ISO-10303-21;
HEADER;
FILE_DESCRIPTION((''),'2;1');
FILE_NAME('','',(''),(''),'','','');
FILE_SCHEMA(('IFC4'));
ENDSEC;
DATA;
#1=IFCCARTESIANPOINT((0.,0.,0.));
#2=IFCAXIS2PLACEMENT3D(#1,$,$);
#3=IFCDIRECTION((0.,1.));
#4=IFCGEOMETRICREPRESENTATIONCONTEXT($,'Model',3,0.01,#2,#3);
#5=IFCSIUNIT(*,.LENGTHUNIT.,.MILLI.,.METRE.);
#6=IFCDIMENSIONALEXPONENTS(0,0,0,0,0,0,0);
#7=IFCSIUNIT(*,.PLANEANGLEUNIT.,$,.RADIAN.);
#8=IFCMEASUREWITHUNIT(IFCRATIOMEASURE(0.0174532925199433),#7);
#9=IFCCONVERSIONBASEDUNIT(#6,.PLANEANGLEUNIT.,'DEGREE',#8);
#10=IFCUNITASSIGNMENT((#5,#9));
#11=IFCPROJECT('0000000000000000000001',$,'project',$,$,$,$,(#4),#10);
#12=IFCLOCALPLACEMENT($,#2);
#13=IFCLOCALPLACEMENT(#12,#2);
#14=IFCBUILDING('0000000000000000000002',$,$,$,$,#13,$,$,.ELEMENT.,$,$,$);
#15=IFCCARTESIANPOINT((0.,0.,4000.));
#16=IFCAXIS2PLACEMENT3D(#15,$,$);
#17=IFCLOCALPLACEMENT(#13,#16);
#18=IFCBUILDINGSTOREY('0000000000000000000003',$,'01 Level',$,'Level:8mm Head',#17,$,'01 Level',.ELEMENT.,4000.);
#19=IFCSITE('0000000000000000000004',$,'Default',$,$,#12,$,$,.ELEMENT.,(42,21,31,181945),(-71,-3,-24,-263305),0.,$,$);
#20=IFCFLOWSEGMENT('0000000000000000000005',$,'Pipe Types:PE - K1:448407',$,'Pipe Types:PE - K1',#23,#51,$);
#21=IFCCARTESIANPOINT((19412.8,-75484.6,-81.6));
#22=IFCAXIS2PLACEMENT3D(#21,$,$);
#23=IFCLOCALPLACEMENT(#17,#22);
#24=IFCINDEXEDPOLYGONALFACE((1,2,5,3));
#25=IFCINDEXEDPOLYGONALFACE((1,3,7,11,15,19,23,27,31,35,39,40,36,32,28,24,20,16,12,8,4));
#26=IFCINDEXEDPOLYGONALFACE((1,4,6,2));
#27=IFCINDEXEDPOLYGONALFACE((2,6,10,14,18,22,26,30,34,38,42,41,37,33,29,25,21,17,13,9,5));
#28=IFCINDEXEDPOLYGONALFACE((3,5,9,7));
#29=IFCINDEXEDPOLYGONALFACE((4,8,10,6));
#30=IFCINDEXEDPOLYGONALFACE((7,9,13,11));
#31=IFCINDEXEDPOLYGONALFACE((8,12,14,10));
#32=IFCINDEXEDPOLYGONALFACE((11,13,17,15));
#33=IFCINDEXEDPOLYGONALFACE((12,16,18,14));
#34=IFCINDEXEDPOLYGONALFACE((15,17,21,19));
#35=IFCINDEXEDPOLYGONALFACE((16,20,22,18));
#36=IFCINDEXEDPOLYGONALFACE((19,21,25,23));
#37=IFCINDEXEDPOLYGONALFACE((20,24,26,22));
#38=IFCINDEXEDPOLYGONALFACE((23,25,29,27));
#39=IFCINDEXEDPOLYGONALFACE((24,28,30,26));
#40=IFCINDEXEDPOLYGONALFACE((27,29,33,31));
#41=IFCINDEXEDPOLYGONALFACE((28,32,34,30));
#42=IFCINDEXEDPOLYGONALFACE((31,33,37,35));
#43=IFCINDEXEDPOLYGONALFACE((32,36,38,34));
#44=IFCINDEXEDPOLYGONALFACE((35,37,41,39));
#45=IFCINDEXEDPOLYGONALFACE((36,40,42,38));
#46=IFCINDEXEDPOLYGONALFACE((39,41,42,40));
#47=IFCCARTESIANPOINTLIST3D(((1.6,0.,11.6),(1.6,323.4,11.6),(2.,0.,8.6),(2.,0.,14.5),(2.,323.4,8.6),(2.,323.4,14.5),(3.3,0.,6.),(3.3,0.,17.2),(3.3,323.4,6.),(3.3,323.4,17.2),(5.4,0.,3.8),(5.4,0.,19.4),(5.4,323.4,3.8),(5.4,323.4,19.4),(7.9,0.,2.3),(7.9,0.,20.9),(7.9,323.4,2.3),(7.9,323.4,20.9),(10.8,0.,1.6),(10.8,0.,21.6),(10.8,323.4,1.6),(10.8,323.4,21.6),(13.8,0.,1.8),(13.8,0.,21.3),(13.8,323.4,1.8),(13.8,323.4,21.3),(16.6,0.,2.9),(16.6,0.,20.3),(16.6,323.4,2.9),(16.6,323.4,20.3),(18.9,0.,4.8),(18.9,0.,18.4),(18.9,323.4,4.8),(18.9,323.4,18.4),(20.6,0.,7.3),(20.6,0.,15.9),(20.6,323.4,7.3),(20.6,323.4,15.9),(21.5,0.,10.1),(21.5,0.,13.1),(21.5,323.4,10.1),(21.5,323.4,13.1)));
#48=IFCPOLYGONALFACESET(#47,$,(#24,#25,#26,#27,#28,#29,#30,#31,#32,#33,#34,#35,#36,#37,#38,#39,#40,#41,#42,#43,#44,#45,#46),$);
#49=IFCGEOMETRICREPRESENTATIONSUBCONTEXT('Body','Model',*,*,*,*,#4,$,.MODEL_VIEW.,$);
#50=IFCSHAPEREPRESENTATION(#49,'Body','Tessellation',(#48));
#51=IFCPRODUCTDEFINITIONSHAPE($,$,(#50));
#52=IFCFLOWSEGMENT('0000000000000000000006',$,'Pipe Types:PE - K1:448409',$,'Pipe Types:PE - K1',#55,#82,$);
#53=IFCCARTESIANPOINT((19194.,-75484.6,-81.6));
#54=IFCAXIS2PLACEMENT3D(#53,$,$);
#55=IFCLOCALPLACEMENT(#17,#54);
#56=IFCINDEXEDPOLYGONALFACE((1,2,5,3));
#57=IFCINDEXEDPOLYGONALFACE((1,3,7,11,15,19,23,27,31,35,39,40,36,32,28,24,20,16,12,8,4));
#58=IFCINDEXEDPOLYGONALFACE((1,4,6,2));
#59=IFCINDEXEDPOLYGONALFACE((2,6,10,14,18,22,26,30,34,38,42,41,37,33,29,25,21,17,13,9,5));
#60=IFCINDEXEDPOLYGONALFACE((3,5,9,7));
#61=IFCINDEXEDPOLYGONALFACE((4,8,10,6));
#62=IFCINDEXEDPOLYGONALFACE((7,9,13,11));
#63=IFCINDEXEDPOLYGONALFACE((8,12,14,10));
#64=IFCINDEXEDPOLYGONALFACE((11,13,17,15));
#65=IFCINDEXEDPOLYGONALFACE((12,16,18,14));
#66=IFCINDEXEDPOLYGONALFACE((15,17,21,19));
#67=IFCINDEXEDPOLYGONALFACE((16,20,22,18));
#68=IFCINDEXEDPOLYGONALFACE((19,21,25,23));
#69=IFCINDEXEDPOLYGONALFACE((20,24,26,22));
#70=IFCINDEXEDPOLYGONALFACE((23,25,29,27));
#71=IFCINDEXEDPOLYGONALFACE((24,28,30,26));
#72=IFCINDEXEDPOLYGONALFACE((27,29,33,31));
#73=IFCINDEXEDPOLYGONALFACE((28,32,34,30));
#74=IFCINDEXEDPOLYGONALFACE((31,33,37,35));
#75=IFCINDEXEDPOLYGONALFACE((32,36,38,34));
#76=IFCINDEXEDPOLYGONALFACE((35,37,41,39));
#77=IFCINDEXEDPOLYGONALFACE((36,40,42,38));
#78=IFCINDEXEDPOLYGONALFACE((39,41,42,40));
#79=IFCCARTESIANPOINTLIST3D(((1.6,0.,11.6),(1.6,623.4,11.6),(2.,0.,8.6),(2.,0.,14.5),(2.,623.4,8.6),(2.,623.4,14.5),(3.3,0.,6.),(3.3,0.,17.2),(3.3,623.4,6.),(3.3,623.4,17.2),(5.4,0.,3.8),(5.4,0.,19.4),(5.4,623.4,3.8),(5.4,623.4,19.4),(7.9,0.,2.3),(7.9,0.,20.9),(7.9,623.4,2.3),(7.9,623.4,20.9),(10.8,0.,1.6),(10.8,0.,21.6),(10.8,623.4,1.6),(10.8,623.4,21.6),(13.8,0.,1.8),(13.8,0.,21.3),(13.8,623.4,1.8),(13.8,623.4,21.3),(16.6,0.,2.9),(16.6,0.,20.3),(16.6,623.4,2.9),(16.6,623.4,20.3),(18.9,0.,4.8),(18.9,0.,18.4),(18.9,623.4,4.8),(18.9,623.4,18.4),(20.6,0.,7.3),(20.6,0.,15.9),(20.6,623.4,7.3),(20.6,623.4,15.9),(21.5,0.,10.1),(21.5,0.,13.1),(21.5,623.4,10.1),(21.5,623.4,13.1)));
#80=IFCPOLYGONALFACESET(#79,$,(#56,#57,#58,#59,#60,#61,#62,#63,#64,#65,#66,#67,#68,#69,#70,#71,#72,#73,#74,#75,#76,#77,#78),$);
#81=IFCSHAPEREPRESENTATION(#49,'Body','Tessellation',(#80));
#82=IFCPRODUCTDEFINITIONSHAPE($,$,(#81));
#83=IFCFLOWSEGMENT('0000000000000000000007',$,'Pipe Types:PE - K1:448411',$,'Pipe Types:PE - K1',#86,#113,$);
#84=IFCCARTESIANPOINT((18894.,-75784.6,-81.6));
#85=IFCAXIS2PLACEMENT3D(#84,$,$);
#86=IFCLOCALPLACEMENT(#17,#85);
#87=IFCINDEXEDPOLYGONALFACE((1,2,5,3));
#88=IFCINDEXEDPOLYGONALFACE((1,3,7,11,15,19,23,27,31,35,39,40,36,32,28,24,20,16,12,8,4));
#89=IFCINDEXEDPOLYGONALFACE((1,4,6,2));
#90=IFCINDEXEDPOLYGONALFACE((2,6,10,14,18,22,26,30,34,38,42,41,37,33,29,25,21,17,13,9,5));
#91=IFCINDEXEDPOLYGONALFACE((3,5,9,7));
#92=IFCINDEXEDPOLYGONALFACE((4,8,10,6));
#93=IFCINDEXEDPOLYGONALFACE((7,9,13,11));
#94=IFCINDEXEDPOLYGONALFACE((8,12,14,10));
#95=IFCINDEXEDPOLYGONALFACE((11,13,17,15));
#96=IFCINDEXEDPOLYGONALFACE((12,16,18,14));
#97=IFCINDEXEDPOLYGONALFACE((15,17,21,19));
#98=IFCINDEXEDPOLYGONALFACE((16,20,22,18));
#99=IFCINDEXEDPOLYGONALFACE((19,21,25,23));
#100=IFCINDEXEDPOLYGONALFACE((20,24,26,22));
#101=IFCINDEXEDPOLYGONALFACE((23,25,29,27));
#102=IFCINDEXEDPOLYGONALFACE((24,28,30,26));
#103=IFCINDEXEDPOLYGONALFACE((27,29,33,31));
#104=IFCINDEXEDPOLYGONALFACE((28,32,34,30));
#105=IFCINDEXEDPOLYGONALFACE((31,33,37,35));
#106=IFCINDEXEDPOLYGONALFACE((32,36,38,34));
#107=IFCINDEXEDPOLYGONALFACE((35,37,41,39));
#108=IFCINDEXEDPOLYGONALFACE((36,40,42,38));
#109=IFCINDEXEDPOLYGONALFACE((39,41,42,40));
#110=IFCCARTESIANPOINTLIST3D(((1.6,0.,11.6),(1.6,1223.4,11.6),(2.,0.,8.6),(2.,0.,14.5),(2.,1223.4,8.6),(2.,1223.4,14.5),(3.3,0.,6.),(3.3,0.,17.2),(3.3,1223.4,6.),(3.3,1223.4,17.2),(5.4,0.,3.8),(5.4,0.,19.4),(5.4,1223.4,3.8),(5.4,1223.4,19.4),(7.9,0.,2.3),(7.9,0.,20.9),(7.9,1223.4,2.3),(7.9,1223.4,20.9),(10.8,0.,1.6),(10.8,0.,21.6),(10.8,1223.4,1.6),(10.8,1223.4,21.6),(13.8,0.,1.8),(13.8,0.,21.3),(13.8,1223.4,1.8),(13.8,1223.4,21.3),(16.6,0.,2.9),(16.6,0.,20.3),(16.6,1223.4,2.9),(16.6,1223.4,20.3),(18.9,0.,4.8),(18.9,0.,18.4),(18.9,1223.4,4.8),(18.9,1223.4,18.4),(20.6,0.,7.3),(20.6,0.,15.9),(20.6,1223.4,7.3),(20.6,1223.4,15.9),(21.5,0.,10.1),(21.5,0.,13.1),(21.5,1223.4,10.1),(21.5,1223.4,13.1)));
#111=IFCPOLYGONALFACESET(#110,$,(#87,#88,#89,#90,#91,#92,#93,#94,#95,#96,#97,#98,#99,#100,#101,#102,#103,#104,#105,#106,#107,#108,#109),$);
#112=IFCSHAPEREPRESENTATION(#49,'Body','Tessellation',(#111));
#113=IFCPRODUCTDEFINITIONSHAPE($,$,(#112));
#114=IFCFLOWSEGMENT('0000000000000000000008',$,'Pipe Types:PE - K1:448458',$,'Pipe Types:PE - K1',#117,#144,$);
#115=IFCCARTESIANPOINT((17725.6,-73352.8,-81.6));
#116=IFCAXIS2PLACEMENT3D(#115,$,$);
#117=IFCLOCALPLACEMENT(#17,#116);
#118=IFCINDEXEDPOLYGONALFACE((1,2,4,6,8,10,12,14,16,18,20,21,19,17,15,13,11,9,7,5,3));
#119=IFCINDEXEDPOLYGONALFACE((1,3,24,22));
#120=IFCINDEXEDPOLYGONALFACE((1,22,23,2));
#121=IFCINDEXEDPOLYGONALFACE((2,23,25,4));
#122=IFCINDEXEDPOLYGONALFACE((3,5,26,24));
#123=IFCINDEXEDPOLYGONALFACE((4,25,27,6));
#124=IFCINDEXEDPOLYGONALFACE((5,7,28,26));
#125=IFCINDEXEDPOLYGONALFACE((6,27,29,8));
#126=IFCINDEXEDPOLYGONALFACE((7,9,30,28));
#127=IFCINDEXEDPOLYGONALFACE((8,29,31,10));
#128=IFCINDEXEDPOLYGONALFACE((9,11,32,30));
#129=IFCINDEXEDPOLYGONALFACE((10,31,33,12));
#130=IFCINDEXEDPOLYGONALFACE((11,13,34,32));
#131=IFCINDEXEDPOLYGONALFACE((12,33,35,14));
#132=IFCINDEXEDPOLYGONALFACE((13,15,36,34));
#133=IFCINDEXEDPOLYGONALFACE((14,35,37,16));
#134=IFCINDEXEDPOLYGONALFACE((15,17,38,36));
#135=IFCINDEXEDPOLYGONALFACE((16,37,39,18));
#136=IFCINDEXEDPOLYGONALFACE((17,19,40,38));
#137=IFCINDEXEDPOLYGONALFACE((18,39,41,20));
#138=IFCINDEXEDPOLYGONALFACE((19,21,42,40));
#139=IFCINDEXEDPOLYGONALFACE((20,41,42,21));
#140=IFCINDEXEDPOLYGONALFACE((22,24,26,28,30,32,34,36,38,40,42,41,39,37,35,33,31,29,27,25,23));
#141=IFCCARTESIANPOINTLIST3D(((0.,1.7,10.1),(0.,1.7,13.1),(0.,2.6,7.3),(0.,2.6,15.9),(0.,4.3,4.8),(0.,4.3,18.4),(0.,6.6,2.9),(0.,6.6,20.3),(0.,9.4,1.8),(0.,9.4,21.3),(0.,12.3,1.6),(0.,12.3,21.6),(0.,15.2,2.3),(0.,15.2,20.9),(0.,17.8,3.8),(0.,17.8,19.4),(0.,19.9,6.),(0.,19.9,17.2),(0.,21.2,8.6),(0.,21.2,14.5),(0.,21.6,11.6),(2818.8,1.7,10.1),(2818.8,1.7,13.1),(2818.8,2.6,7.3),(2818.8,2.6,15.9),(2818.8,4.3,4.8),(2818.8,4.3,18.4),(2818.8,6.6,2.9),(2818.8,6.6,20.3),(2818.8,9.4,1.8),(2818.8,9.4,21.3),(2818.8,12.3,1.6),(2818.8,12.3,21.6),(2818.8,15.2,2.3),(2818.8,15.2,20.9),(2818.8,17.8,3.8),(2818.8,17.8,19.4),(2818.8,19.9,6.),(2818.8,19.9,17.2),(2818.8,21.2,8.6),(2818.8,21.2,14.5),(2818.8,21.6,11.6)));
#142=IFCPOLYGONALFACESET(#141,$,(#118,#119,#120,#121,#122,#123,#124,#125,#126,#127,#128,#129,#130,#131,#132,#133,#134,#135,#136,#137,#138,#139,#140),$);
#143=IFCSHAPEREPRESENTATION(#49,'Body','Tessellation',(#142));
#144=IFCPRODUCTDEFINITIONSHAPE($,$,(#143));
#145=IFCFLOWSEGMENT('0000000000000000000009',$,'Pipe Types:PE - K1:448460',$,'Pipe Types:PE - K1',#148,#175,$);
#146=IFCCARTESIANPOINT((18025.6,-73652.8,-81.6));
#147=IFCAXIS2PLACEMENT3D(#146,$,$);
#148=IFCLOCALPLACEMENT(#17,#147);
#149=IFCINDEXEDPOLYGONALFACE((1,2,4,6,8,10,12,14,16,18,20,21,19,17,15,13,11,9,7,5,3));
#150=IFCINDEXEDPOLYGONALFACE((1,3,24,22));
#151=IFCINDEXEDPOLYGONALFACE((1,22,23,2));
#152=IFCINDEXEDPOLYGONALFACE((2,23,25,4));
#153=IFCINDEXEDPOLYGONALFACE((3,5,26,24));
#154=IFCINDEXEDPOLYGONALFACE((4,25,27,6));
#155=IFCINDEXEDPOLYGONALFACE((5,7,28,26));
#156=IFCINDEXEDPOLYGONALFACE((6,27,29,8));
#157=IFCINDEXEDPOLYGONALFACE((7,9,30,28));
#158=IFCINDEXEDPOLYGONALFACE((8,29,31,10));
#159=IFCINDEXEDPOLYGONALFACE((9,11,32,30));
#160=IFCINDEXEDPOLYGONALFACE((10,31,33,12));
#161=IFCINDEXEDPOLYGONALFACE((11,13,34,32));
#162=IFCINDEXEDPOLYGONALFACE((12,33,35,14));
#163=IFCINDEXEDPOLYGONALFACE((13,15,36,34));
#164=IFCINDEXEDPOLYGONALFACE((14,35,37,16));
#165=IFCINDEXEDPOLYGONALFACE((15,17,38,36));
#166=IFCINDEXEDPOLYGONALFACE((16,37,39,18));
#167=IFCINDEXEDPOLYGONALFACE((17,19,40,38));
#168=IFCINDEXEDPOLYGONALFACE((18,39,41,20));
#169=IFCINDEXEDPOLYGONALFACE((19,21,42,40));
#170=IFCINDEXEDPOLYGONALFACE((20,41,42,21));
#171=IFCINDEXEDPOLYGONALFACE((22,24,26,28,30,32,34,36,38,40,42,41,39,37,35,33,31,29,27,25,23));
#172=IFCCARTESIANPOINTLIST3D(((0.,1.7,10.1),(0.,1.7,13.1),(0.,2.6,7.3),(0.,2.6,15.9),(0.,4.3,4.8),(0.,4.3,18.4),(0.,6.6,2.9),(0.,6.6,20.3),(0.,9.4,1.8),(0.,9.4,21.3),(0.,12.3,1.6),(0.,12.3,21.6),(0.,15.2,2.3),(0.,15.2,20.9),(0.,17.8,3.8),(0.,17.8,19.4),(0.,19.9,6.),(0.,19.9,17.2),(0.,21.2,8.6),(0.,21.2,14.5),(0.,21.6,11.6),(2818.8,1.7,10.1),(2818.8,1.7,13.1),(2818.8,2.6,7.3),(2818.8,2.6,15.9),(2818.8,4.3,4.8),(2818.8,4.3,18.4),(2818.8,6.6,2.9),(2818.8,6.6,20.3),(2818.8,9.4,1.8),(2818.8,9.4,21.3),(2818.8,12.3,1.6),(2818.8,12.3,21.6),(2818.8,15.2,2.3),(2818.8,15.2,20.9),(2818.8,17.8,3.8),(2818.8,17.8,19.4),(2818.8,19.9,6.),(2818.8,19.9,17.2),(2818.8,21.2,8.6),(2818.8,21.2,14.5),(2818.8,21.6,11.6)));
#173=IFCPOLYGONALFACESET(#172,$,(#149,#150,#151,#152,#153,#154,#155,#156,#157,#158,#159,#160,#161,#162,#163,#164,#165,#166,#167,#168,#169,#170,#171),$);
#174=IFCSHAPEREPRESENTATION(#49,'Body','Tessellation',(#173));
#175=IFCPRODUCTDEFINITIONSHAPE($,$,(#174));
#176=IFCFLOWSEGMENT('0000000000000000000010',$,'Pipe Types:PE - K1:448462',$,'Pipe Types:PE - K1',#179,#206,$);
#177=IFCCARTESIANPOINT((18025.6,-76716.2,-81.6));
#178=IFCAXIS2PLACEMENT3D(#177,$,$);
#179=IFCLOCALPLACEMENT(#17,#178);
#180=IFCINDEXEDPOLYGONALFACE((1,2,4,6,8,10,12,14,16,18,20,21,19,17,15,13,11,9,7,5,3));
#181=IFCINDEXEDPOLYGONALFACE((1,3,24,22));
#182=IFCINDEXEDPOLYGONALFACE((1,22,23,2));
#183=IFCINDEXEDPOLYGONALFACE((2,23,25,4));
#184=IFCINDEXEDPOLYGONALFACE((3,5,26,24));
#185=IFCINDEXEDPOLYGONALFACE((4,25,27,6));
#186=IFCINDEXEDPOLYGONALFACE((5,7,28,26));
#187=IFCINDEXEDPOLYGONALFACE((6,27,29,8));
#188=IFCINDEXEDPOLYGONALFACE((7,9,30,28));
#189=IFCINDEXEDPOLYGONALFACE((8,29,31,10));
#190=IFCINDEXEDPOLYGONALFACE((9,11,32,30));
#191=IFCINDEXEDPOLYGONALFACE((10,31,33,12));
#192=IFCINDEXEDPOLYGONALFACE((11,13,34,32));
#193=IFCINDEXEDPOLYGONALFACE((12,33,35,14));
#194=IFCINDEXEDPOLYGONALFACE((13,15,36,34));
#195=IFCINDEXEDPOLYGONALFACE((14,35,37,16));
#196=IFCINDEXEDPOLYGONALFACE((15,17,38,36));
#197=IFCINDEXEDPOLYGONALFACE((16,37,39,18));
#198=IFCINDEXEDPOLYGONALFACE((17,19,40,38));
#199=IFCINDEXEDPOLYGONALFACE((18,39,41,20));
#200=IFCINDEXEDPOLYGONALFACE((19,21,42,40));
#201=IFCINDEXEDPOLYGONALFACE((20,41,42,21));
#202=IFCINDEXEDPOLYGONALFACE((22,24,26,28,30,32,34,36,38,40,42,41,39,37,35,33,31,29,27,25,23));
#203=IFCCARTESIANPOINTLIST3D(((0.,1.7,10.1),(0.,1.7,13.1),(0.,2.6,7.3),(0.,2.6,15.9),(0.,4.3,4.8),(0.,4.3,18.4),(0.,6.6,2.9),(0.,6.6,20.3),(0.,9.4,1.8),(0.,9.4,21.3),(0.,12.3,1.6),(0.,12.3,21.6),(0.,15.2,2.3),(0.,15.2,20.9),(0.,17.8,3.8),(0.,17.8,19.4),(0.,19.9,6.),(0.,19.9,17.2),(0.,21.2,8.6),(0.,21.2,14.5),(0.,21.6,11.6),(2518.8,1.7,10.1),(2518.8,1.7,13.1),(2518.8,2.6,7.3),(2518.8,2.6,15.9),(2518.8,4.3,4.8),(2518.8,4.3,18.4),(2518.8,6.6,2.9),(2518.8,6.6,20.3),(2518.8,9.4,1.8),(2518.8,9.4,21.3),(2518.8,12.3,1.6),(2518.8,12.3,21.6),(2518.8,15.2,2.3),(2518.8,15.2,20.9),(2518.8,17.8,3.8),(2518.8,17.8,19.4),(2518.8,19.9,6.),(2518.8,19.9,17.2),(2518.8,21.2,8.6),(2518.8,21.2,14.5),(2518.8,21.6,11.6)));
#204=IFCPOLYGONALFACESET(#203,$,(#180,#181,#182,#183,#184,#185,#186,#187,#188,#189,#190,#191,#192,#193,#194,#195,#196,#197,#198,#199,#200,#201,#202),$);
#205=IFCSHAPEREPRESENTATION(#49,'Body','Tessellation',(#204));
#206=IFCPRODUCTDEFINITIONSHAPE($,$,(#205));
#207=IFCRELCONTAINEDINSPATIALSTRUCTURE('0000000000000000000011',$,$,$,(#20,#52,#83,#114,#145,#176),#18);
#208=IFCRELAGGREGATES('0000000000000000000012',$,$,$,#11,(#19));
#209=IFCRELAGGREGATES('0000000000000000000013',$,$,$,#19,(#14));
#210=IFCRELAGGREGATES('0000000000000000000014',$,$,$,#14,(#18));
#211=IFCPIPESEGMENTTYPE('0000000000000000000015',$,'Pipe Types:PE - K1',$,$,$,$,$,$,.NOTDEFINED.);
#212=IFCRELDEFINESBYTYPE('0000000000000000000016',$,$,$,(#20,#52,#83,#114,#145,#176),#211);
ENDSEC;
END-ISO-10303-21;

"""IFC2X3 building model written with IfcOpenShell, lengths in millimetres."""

from ifc_helpers import new_model, entity, si_unit, converted_unit, direction, frame, frame_2d, origin, place, context, subcontext, project, spatial, circle, extrude, type_object, element, save


model = new_model("IFC2X3")

# Units and contexts
model_context = context("Model", 3, precision=0.01, world=origin(), true_north=direction((0.0, 1.0)))
body_context = subcontext(model_context, "Body", "Model", "MODEL_VIEW")
ifc_project = project(units=[si_unit("LENGTHUNIT", "METRE", prefix="MILLI"), converted_unit("PLANEANGLEUNIT", "DEGREE", entity("IfcRatioMeasure", 0.0174532925199433), si_unit("PLANEANGLEUNIT", "RADIAN"), dimensions=[0, 0, 0, 0, 0, 0, 0])], contexts=[model_context])

# Site, building, storey
site_placement = place(None, origin())
site = spatial("IfcSite", under=ifc_project, at=site_placement, Name="Default", CompositionType="ELEMENT", RefLatitude=(42, 21, 31, 181945), RefLongitude=(-71, -3, -24, -263305), RefElevation=0.0)
building_placement = place(site_placement, origin())
building = spatial("IfcBuilding", under=site, at=building_placement, CompositionType="ELEMENT")
storey_placement = place(building_placement, frame((0.0, 0.0, 4000.0)))
storey = spatial("IfcBuildingStorey", under=building, at=storey_placement, Name="01 Level", ObjectType="Level:8mm Head", LongName="01 Level", CompositionType="ELEMENT", Elevation=4000.0)

# Flow segments
pipe_segment_type = type_object("IfcPipeSegmentType", Name="Pipe Types:PE - K1", PredefinedType="NOTDEFINED")
flow_segment_1_placement = place(storey_placement, frame((19412.8, -75484.6, -81.6)))
element("IfcFlowSegment", 1, at=flow_segment_1_placement, inside=storey, type_object=pipe_segment_type, Name="Pipe Types:PE - K1:448407", ObjectType="Pipe Types:PE - K1", context=body_context, shape_type="SweptSolid", body=[
    extrude(circle(Radius=10.0, at=frame_2d((0.0, 0.0), x_axis=(1.0, 0.0))), frame((11.6, 0.0, 11.6), z_axis=(0.0, 1.0, 0.0), x_axis=(-1.0, 0.0, 0.0)), (0.0, 0.0, 1.0), 323.4),
])
flow_segment_2_placement = place(storey_placement, frame((19194.0, -75484.6, -81.6)))
element("IfcFlowSegment", 2, at=flow_segment_2_placement, inside=storey, type_object=pipe_segment_type, Name="Pipe Types:PE - K1:448409", ObjectType="Pipe Types:PE - K1", context=body_context, shape_type="SweptSolid", body=[
    extrude(circle(Radius=10.0, at=frame_2d((0.0, 0.0), x_axis=(1.0, 0.0))), frame((11.6, 0.0, 11.6), z_axis=(0.0, 1.0, 0.0), x_axis=(-1.0, 0.0, 0.0)), (0.0, 0.0, 1.0), 623.4),
])
flow_segment_3_placement = place(storey_placement, frame((18894.0, -75784.6, -81.6)))
element("IfcFlowSegment", 3, at=flow_segment_3_placement, inside=storey, type_object=pipe_segment_type, Name="Pipe Types:PE - K1:448411", ObjectType="Pipe Types:PE - K1", context=body_context, shape_type="SweptSolid", body=[
    extrude(circle(Radius=10.0, at=frame_2d((0.0, 0.0), x_axis=(1.0, 0.0))), frame((11.6, 0.0, 11.6), z_axis=(0.0, 1.0, 0.0), x_axis=(-1.0, 0.0, 0.0)), (0.0, 0.0, 1.0), 1223.4),
])
for number, where, name in (
    (4, (17725.6, -73352.8, -81.6), "Pipe Types:PE - K1:448458"),
    (5, (18025.6, -73652.8, -81.6), "Pipe Types:PE - K1:448460"),
):
    element("IfcFlowSegment", number, at=place(storey_placement, frame(where)), inside=storey, type_object=pipe_segment_type, Name=name, ObjectType="Pipe Types:PE - K1", context=body_context, shape_type="SweptSolid", body=[
        extrude(circle(Radius=10.0, at=frame_2d((0.0, 0.0), x_axis=(1.0, 0.0))), frame((0.0, 11.6, 11.6), z_axis=(1.0, 0.0, 0.0), x_axis=(0.0, 1.0, 0.0)), (0.0, 0.0, 1.0), 2818.8),
    ])
flow_segment_4_placement = place(storey_placement, frame((18025.6, -76716.2, -81.6)))
element("IfcFlowSegment", 6, at=flow_segment_4_placement, inside=storey, type_object=pipe_segment_type, Name="Pipe Types:PE - K1:448462", ObjectType="Pipe Types:PE - K1", context=body_context, shape_type="SweptSolid", body=[
    extrude(circle(Radius=10.0, at=frame_2d((0.0, 0.0), x_axis=(1.0, 0.0))), frame((0.0, 11.6, 11.6), z_axis=(1.0, 0.0, 0.0), x_axis=(0.0, 1.0, 0.0)), (0.0, 0.0, 1.0), 2518.8),
])

save(model, "model.ifc")
